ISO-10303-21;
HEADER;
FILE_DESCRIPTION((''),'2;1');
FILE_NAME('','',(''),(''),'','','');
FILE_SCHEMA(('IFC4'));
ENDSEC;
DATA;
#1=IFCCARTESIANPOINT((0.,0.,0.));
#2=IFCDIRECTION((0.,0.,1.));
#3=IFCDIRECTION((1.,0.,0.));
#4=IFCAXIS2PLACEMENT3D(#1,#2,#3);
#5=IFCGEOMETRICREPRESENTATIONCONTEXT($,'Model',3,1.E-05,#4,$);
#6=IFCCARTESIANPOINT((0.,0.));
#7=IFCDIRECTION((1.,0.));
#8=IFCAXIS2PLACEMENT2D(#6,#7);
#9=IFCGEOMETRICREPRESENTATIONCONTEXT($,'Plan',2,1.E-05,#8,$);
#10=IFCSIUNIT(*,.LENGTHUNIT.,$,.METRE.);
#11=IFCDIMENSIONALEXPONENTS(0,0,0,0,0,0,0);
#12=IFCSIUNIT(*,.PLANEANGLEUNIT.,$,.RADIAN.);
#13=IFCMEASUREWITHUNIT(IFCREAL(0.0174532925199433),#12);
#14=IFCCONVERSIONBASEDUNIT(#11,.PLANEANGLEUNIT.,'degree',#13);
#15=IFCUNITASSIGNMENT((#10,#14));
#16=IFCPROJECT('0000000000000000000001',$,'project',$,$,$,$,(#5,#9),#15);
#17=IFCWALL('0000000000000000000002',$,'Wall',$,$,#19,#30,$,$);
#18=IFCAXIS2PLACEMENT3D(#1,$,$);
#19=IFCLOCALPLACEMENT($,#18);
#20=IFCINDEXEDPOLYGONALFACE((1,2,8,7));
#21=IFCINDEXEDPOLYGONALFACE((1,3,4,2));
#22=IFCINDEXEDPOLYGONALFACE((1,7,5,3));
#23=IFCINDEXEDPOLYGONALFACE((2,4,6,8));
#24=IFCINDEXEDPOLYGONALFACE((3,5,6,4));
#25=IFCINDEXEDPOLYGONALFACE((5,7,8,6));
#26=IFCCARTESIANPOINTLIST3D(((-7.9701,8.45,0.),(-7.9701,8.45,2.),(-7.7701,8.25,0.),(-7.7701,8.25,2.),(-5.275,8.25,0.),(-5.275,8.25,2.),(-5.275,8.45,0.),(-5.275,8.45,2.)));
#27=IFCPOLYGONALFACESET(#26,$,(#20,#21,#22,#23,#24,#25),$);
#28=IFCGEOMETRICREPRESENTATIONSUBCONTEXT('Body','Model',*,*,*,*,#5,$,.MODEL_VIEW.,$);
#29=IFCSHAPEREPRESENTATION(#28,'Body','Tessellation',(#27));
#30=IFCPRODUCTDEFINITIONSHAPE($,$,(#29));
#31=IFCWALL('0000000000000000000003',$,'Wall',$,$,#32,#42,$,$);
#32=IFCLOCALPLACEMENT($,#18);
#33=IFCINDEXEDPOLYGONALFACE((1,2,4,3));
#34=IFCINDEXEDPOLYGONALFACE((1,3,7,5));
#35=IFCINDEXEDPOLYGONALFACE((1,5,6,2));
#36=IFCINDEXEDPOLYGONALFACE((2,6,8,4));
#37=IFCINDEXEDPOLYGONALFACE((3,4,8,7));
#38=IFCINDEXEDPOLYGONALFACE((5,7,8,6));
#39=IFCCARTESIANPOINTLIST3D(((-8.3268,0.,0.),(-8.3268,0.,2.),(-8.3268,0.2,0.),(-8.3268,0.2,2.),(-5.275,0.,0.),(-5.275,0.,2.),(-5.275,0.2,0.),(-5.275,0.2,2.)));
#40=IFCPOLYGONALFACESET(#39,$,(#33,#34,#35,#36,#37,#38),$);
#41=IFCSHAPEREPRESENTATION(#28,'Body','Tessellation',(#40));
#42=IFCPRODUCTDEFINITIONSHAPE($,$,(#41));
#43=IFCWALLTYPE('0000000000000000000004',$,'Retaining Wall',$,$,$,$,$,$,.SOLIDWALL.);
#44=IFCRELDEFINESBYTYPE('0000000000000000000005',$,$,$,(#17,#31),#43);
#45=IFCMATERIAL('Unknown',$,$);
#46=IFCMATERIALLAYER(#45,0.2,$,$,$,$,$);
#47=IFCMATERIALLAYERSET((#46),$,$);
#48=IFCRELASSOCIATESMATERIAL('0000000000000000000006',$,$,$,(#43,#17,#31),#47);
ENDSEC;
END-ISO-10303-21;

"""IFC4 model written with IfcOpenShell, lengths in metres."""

from ifc_helpers import new_model, entity, si_unit, converted_unit, frame, origin_with_axes, origin_2d_with_axis, place, context, subcontext, project, indexed_curve, outline, extrude, clip, halfspace, material, layer, layer_set, layer_usage, type_object, element, save


model = new_model("IFC4")

# Units and contexts
model_context = context("Model", 3, precision=1e-05, world=origin_with_axes())
plan_context = context("Plan", 2, precision=1e-05, world=origin_2d_with_axis())
body_context = subcontext(model_context, "Body", "Model", "MODEL_VIEW")
ifc_project = project(units=[si_unit("LENGTHUNIT", "METRE"), converted_unit("PLANEANGLEUNIT", "degree", entity("IfcReal", 0.0174532925199433), si_unit("PLANEANGLEUNIT", "RADIAN"), dimensions=[0, 0, 0, 0, 0, 0, 0])], contexts=[model_context, plan_context])

# Shared definitions
ifc_material = material(Name="Unknown")

# Walls
ifc_layer_1 = layer(ifc_material, 0.2)
ifc_layer_set_1 = layer_set([ifc_layer_1])
wall_type_1 = type_object("IfcWallType", Name="Retaining Wall", PredefinedType="SOLIDWALL", material=ifc_layer_set_1)
ifc_layer_usage_1 = layer_usage(ifc_layer_set_1, "AXIS2", "POSITIVE", 0.0)
wall_1_placement = place(None, frame((-5.275, 8.45, 0.0), z_axis=(0.0, 0.0, 1.0), x_axis=(-1.0, 0.0, 0.0)))
element("IfcWall", 1, at=wall_1_placement, type_object=wall_type_1, material=ifc_layer_usage_1, Name="Wall", context=body_context, shape_type="Clipping", body=[
    clip(extrude(outline(indexed_curve([(0.0, 0.0), (0.0, 0.2), (2.6951, 0.2), (2.6951, 0.0), (0.0, 0.0)], self_intersect=False)), origin_with_axes(), (0.0, 0.0, 1.0), 2.0), halfspace(frame((2.6951, 0.0, 0.0), z_axis=(0.707107, 0.707106, 0.0), x_axis=(0.707106, -0.707107, 0.0)), False)),
])
ifc_layer_usage_2 = layer_usage(ifc_layer_set_1, "AXIS2", "POSITIVE", 0.0)
wall_2_placement = place(None, frame((-8.3268, 0.0, 0.0), z_axis=(0.0, 0.0, 1.0), x_axis=(1.0, 0.0, 0.0)))
element("IfcWall", 2, at=wall_2_placement, type_object=wall_type_1, material=ifc_layer_usage_2, Name="Wall", context=body_context, shape_type="SweptSolid", body=[
    extrude(outline(indexed_curve([(0.0, 0.0), (0.0, 0.2), (3.0518, 0.2), (3.0518, 0.0), (0.0, 0.0)], self_intersect=False)), origin_with_axes(), (0.0, 0.0, 1.0), 2.0),
])

save(model, "model.ifc")
